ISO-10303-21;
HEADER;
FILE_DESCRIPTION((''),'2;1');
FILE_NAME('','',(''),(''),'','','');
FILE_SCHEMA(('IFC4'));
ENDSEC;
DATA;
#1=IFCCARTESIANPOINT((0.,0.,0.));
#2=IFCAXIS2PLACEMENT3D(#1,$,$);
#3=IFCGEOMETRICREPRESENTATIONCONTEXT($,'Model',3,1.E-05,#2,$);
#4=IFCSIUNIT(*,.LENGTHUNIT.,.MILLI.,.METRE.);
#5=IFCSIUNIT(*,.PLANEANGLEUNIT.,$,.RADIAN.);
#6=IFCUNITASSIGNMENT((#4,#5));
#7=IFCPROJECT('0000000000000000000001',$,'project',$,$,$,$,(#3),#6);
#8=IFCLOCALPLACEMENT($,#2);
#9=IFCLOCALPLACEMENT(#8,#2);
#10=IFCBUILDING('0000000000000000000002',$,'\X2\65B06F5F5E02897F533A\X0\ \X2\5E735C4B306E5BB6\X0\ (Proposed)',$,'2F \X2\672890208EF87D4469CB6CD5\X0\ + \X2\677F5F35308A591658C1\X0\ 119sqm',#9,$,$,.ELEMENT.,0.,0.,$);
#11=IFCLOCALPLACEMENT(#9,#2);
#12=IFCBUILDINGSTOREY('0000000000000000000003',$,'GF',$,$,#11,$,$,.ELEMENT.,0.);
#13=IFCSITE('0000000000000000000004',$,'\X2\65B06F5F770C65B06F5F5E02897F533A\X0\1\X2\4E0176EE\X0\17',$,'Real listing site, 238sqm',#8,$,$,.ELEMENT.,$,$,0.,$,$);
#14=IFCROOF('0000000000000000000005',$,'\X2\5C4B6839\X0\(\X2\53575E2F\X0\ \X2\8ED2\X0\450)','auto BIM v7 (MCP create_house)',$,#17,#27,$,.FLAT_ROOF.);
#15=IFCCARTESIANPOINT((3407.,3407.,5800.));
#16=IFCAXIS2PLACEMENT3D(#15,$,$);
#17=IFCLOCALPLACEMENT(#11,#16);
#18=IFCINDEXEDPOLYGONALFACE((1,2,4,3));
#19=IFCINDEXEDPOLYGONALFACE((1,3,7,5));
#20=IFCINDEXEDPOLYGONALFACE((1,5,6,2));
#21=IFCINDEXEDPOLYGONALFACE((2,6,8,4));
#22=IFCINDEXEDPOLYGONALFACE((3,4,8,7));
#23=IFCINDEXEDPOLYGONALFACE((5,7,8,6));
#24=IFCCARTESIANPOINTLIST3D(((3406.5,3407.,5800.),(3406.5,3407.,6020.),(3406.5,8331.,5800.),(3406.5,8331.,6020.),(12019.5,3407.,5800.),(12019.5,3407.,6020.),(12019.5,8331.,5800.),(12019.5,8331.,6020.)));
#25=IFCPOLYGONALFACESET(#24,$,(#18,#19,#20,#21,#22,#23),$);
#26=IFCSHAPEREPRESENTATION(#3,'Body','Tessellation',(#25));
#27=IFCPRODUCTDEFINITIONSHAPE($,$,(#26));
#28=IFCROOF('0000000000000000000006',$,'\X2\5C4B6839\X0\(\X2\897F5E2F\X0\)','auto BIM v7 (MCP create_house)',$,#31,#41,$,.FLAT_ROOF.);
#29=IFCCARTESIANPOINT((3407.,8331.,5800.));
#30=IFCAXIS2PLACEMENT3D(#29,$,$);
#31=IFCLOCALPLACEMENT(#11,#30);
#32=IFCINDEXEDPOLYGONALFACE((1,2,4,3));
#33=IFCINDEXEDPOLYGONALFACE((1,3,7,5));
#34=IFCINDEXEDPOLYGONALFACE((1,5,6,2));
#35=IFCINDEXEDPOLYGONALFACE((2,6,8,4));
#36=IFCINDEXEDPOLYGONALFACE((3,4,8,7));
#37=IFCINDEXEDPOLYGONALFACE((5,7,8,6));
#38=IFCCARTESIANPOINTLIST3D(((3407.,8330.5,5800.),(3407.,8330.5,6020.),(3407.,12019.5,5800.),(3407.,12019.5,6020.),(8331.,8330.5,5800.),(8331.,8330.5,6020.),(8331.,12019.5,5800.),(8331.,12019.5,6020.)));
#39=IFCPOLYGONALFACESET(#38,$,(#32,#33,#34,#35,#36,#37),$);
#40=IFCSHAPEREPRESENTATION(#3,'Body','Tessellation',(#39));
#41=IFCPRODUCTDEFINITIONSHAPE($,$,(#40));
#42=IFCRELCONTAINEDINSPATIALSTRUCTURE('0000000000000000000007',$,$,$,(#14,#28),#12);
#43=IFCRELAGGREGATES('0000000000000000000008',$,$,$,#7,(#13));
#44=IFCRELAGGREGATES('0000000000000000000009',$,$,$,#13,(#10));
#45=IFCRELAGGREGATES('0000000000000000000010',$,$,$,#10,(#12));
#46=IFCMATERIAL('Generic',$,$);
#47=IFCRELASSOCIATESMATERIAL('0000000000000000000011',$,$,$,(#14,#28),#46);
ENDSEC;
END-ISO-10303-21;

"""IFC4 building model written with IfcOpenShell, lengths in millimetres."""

from ifc_helpers import new_model, si_unit, frame, frame_2d, origin, place, context, project, spatial, rectangle, extrude, material, element, save


model = new_model("IFC4")

# Units and contexts
model_context = context("Model", 3, precision=1e-05, world=origin())
ifc_project = project(units=[si_unit("LENGTHUNIT", "METRE", prefix="MILLI"), si_unit("PLANEANGLEUNIT", "RADIAN")], contexts=[model_context])

# Site, building, storey
site_placement = place(None, origin())
site = spatial("IfcSite", under=ifc_project, at=site_placement, Name="新潟県新潟市西区1丁目17", ObjectType="Real listing site, 238sqm", CompositionType="ELEMENT", RefElevation=0.0)
building_placement = place(site_placement, origin())
building = spatial("IfcBuilding", under=site, at=building_placement, Name="新潟市西区 平屋の家 (Proposed)", ObjectType="2F 木造軸組構法 + 板張り外壁 119sqm", CompositionType="ELEMENT", ElevationOfRefHeight=0.0, ElevationOfTerrain=0.0)
storey_placement = place(building_placement, origin())
storey = spatial("IfcBuildingStorey", under=building, at=storey_placement, Name="GF", CompositionType="ELEMENT", Elevation=0.0)

# Shared definitions
ifc_material = material(Name="Generic")

# Roofs
roof_1_placement = place(storey_placement, frame((3407.0, 3407.0, 5800.0)))
element("IfcRoof", 1, at=roof_1_placement, inside=storey, material=ifc_material, Name="屋根(南帯 軒450)", Description="auto BIM v7 (MCP create_house)", PredefinedType="FLAT_ROOF", context=model_context, shape_type="SweptSolid", body=[
    extrude(rectangle(XDim=8613.0, YDim=4924.0, at=frame_2d((4306.0, 2462.0))), frame((3407.0, 3407.0, 5800.0)), (0.0, 0.0, 1.0), 220.0),
])
roof_2_placement = place(storey_placement, frame((3407.0, 8331.0, 5800.0)))
element("IfcRoof", 2, at=roof_2_placement, inside=storey, material=ifc_material, Name="屋根(西帯)", Description="auto BIM v7 (MCP create_house)", PredefinedType="FLAT_ROOF", context=model_context, shape_type="SweptSolid", body=[
    extrude(rectangle(XDim=4924.0, YDim=3689.0, at=frame_2d((2462.0, 1844.0))), frame((3407.0, 8331.0, 5800.0)), (0.0, 0.0, 1.0), 220.0),
])

save(model, "model.ifc")
